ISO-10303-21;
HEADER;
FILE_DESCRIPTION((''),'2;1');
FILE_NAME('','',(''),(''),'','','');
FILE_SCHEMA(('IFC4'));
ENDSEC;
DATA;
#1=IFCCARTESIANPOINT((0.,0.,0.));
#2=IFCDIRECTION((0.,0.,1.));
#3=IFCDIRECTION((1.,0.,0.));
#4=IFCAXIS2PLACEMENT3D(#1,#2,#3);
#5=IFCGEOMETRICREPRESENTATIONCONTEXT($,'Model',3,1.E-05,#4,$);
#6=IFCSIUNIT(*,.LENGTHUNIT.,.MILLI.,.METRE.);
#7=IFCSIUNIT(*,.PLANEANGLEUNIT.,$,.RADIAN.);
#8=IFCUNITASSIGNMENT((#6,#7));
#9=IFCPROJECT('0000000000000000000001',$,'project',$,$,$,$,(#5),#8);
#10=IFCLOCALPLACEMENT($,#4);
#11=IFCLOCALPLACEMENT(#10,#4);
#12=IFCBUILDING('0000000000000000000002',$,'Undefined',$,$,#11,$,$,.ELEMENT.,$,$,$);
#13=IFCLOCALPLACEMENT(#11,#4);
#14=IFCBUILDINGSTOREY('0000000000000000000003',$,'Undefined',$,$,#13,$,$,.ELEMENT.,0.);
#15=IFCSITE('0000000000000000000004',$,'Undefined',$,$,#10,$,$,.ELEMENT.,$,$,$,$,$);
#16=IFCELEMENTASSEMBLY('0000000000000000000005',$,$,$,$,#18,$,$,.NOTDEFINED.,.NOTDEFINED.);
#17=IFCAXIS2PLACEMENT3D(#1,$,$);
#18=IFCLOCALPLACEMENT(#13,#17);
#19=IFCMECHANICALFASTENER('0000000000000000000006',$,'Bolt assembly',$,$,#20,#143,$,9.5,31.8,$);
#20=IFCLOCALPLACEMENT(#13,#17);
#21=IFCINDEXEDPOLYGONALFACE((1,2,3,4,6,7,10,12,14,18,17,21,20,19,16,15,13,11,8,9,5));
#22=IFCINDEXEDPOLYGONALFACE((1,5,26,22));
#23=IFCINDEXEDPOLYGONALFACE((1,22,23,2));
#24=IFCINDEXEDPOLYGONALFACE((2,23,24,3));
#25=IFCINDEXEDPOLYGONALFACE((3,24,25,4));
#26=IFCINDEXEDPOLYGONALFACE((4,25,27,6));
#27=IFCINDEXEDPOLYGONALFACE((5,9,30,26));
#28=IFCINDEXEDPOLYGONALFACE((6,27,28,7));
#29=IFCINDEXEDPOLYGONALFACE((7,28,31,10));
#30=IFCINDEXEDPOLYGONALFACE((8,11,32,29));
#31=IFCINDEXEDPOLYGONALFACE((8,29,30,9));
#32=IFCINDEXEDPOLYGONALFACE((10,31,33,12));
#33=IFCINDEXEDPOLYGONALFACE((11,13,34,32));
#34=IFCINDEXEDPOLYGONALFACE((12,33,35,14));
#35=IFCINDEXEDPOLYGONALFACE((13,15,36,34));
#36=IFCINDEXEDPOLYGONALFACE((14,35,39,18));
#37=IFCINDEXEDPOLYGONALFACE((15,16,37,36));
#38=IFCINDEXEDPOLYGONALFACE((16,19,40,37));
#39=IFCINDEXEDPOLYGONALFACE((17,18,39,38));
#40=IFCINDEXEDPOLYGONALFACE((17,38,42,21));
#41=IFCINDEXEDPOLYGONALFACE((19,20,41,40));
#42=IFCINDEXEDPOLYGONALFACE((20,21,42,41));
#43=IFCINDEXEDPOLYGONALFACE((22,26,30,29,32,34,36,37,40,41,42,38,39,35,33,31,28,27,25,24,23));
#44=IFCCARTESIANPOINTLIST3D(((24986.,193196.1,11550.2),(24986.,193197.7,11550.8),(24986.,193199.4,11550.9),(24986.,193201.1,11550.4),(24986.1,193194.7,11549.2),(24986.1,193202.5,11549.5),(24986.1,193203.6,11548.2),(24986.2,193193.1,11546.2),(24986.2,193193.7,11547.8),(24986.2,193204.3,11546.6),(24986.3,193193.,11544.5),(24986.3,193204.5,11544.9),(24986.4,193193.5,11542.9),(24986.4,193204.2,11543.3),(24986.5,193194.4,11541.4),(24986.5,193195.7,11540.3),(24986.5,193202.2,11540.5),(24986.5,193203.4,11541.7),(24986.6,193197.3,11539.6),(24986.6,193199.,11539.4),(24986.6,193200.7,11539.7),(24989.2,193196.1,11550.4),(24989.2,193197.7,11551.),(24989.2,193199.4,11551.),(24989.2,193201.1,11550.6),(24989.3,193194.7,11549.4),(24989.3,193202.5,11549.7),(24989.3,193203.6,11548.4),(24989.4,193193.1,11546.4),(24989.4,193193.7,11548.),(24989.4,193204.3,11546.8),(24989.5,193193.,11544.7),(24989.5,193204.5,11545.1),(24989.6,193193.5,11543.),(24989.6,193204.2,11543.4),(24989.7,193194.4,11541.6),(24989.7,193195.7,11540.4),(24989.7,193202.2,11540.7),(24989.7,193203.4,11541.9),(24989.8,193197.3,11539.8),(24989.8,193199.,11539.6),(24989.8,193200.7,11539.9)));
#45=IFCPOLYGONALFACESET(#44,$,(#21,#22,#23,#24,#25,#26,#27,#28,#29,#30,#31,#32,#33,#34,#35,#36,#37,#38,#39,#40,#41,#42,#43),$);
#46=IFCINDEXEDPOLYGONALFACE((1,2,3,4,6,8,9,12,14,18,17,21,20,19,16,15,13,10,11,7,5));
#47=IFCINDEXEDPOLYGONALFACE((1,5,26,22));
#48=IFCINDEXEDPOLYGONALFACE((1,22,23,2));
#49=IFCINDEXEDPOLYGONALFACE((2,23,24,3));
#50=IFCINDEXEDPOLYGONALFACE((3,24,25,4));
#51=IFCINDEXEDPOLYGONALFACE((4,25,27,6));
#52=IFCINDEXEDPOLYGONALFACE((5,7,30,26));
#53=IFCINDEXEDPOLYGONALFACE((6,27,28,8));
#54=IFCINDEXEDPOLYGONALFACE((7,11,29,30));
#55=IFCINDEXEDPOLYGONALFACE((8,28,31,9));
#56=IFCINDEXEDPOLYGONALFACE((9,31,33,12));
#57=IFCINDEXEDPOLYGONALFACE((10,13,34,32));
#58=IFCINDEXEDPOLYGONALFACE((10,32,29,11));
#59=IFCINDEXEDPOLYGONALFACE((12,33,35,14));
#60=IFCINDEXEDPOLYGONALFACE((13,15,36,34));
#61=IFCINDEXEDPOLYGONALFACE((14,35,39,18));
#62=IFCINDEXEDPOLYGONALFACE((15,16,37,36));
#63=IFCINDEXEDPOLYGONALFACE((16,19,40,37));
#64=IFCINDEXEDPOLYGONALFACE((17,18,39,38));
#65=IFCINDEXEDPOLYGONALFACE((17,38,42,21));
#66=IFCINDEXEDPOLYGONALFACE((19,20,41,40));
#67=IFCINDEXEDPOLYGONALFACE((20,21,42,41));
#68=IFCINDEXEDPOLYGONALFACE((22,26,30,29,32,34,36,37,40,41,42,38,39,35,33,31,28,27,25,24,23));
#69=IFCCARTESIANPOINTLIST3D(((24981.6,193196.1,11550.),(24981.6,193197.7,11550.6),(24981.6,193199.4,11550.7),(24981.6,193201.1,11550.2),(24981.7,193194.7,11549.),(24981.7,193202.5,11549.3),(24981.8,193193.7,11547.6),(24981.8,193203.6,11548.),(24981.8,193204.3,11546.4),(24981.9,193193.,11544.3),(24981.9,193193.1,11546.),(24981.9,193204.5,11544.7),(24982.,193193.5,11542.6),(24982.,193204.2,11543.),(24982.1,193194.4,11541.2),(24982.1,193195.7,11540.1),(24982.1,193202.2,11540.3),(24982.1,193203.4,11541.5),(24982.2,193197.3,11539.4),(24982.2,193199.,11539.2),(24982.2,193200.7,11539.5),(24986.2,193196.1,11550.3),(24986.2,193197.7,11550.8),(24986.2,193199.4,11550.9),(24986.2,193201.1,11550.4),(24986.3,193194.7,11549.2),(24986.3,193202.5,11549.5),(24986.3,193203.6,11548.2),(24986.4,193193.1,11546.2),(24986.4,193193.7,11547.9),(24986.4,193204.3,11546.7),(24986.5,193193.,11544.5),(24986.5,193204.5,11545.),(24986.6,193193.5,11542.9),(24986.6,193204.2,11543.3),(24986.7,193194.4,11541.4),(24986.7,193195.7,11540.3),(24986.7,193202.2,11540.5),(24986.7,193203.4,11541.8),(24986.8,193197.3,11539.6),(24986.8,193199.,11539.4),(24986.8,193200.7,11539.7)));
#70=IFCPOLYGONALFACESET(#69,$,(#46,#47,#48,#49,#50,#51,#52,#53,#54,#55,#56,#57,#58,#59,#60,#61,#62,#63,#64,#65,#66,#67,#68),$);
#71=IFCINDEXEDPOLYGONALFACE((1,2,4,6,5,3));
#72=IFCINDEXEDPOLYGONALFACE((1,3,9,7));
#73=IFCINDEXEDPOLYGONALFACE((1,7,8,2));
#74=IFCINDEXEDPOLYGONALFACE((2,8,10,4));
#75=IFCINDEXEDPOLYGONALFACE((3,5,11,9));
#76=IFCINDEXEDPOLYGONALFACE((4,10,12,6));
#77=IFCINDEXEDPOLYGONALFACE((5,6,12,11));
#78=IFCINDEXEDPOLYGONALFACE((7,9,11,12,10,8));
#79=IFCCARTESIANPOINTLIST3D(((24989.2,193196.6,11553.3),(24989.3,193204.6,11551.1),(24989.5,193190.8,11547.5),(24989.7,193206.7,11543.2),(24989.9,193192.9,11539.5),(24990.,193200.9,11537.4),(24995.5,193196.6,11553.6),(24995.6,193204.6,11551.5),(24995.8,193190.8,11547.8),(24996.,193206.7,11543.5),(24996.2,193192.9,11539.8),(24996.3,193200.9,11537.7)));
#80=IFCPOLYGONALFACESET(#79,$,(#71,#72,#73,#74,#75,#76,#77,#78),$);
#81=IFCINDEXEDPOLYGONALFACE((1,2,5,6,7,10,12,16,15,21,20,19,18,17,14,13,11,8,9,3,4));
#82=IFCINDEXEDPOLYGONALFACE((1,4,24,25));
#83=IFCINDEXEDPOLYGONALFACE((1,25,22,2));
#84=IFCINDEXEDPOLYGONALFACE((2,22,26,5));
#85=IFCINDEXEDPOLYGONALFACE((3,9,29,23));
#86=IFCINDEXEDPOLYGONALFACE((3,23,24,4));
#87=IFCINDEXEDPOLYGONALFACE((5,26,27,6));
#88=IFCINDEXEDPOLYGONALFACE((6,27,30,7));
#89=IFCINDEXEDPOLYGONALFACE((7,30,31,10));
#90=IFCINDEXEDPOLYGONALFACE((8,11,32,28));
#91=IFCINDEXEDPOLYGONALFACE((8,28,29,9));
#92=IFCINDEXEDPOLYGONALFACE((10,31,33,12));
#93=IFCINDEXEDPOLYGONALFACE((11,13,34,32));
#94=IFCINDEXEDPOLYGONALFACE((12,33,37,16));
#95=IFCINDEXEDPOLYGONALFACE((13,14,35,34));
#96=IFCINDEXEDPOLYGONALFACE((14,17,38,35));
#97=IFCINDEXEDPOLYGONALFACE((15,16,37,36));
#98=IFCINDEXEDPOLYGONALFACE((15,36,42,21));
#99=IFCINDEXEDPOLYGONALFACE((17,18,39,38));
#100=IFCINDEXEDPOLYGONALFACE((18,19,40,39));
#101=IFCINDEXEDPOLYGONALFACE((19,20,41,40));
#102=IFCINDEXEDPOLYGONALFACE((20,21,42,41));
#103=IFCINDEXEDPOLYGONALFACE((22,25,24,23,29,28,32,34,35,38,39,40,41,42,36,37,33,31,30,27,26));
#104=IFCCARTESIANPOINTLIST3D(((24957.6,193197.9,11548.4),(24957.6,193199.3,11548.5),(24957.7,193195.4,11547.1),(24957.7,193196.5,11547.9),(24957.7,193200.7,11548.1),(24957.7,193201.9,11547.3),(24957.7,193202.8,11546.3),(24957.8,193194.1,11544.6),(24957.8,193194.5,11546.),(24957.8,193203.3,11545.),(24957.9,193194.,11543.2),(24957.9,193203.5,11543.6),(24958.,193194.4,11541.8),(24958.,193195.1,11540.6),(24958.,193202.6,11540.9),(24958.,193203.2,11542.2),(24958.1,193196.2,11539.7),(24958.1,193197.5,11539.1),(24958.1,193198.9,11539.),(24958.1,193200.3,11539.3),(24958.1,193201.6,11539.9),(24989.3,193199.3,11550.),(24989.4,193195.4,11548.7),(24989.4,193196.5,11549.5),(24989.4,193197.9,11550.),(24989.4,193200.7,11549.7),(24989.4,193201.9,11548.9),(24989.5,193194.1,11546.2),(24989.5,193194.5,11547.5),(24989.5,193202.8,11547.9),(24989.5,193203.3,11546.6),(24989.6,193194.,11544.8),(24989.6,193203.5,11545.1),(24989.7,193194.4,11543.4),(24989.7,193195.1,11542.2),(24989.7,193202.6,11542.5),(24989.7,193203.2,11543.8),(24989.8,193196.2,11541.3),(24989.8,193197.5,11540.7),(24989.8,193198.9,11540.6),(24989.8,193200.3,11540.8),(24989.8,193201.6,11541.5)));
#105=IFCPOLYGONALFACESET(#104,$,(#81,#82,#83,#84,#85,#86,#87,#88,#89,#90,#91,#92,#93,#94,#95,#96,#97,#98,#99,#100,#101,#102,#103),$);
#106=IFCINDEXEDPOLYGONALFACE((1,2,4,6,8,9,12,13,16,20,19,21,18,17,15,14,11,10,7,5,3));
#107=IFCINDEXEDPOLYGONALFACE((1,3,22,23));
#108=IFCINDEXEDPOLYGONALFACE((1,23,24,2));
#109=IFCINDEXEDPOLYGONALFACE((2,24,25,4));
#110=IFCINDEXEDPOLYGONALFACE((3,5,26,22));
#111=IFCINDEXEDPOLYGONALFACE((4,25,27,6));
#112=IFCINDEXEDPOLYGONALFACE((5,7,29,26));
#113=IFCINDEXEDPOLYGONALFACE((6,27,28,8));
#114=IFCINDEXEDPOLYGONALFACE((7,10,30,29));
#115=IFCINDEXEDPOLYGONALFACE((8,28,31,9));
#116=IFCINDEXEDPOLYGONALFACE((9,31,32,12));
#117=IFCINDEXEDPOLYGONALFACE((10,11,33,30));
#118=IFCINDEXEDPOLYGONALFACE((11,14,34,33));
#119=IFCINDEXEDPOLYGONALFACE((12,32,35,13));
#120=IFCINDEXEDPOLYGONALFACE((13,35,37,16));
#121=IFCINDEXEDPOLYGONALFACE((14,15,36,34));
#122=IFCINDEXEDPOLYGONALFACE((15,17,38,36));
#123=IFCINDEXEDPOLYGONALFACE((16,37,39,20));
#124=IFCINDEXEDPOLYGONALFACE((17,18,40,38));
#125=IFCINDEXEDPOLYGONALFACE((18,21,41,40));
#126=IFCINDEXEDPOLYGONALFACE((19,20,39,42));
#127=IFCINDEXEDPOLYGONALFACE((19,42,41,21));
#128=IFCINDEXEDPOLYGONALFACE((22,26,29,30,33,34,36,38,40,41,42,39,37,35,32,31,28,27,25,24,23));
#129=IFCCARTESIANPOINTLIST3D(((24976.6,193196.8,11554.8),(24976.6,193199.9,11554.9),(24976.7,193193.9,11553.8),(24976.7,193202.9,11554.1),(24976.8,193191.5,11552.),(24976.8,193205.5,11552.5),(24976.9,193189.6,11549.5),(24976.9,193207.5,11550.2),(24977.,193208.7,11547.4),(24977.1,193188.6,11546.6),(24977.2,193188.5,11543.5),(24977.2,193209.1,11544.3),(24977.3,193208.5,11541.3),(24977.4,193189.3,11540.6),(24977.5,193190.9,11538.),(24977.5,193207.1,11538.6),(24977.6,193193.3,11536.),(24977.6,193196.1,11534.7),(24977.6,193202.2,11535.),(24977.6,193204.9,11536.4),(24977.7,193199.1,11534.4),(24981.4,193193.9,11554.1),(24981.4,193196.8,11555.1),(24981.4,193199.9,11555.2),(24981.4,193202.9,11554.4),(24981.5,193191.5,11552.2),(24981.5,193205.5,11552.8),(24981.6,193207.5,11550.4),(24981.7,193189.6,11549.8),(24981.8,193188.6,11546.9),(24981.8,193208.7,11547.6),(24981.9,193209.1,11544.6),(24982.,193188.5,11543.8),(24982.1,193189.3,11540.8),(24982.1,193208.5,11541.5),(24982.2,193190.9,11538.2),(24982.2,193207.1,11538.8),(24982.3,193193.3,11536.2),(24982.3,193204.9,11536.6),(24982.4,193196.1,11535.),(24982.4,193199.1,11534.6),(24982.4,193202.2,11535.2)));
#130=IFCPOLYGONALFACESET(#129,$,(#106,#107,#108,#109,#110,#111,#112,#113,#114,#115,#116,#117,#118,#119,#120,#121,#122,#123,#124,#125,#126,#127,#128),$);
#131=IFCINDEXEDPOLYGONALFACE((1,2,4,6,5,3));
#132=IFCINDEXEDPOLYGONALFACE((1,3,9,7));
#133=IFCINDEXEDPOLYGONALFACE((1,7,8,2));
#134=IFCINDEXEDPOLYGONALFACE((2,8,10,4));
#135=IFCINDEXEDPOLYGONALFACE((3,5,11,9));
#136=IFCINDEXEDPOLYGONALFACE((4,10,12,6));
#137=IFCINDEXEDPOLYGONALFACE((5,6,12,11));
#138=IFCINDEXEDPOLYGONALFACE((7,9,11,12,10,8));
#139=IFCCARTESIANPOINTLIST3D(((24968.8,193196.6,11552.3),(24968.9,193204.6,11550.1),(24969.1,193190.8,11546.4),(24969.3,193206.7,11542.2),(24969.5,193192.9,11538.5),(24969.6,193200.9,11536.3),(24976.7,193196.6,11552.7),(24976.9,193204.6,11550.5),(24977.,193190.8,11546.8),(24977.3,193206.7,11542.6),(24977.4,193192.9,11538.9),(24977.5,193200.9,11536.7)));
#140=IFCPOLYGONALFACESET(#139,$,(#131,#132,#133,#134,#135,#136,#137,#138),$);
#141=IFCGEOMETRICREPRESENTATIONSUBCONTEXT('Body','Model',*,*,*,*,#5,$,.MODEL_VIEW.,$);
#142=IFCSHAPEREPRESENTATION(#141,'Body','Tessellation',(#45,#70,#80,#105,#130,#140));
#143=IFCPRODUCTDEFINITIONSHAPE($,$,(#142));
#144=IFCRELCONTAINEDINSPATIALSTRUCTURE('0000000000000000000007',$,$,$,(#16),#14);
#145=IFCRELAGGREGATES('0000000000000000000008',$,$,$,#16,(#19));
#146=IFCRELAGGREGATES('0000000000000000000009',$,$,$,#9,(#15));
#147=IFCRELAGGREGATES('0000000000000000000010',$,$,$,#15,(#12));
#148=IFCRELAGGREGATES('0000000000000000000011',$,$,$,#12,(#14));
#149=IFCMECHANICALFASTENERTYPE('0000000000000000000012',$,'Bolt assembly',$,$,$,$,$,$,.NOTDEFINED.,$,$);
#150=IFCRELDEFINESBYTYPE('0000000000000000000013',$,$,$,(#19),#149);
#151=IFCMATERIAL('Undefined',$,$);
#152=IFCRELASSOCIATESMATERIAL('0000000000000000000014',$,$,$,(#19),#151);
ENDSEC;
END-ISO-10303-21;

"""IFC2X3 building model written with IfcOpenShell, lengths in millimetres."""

from ifc_helpers import new_model, si_unit, frame, origin_with_axes, origin_2d_with_axis, place, context, subcontext, project, spatial, polyline, circle, outline, extrude, source, transform, mapped, material, type_object, element, aggregate, save


model = new_model("IFC2X3")

# Units and contexts
model_context = context("Model", 3, precision=1e-05, world=origin_with_axes())
body_context = subcontext(model_context, "Body", "Model", "MODEL_VIEW")
ifc_project = project(units=[si_unit("LENGTHUNIT", "METRE", prefix="MILLI"), si_unit("PLANEANGLEUNIT", "RADIAN")], contexts=[model_context])

# Site, building, storey
site_placement = place(None, origin_with_axes())
site = spatial("IfcSite", under=ifc_project, at=site_placement, Name="Undefined", CompositionType="ELEMENT")
building_placement = place(site_placement, origin_with_axes())
building = spatial("IfcBuilding", under=site, at=building_placement, Name="Undefined", CompositionType="ELEMENT")
storey_placement = place(building_placement, origin_with_axes())
storey = spatial("IfcBuildingStorey", under=building, at=storey_placement, Name="Undefined", CompositionType="ELEMENT", Elevation=0.0)

# Element assembly
assembly_1_placement = place(storey_placement, origin_with_axes())
assembly_1 = element("IfcElementAssembly", 1, at=assembly_1_placement, inside=storey, AssemblyPlace="NOTDEFINED", PredefinedType="NOTDEFINED")

# Mechanical fastener
ifc_material_1 = material(Name="Undefined")
mechanical_fastener_type = type_object("IfcMechanicalFastenerType", Name="Bolt assembly")
shared_shape_1 = source(origin_with_axes(), body_context, "Body", "SweptSolid", [
    extrude(circle(Radius=5.8, at=origin_2d_with_axis()), frame((0.0, -7.6, 0.0), z_axis=(0.0, 1.0, 0.0), x_axis=(1.0, 0.0, 0.0)), (0.0, 0.0, 1.0), 3.2),
    extrude(circle(Radius=5.8, at=origin_2d_with_axis()), frame((0.0, -4.6, 0.0), z_axis=(0.0, 1.0, 0.0), x_axis=(1.0, 0.0, 0.0)), (0.0, 0.0, 1.0), 4.6),
    extrude(outline(polyline([(7.1, -4.1), (7.1, 4.1), (0.0, 8.2), (-7.1, 4.1), (-7.1, -4.1), (0.0, -8.2), (7.1, -4.1)])), frame((0.0, -14.0, 0.0), z_axis=(0.0, 1.0, 0.0), x_axis=(1.0, 0.0, 0.0)), (0.0, 0.0, 1.0), 6.3),
    extrude(circle(Radius=4.8, at=origin_2d_with_axis()), frame((0.0, -7.7, 0.0), z_axis=(0.0, 1.0, 0.0), x_axis=(1.0, 0.0, 0.0)), (0.0, 0.0, 1.0), 31.8),
    extrude(circle(Radius=10.3, at=origin_2d_with_axis()), frame((0.0, 0.0, 0.0), z_axis=(0.0, 1.0, 0.0), x_axis=(1.0, 0.0, 0.0)), (0.0, 0.0, 1.0), 4.8),
    extrude(outline(polyline([(7.1, -4.1), (7.1, 4.1), (0.0, 8.2), (-7.1, 4.1), (-7.1, -4.1), (0.0, -8.2), (7.1, -4.1)])), frame((0.0, 4.8, 0.0), z_axis=(0.0, 1.0, 0.0), x_axis=(1.0, 0.0, 0.0)), (0.0, 0.0, 1.0), 7.9),
])
mechanical_fastener_1_placement = place(assembly_1_placement, frame((24981.9, 193198.8, 11544.9), z_axis=(0.035282, -0.707107, -0.706226), x_axis=(-0.035282, -0.707107, 0.706226)))
mechanical_fastener_1 = element("IfcMechanicalFastener", 2, at=mechanical_fastener_1_placement, type_object=mechanical_fastener_type, material=ifc_material_1, Name="Bolt assembly", NominalDiameter=9.5, NominalLength=31.8, context=body_context, shape_type="MappedRepresentation", body=[
    mapped(shared_shape_1, transform((0.0, 0.0, 0.0))),
])

aggregate(assembly_1, [mechanical_fastener_1])

save(model, "model.ifc")
